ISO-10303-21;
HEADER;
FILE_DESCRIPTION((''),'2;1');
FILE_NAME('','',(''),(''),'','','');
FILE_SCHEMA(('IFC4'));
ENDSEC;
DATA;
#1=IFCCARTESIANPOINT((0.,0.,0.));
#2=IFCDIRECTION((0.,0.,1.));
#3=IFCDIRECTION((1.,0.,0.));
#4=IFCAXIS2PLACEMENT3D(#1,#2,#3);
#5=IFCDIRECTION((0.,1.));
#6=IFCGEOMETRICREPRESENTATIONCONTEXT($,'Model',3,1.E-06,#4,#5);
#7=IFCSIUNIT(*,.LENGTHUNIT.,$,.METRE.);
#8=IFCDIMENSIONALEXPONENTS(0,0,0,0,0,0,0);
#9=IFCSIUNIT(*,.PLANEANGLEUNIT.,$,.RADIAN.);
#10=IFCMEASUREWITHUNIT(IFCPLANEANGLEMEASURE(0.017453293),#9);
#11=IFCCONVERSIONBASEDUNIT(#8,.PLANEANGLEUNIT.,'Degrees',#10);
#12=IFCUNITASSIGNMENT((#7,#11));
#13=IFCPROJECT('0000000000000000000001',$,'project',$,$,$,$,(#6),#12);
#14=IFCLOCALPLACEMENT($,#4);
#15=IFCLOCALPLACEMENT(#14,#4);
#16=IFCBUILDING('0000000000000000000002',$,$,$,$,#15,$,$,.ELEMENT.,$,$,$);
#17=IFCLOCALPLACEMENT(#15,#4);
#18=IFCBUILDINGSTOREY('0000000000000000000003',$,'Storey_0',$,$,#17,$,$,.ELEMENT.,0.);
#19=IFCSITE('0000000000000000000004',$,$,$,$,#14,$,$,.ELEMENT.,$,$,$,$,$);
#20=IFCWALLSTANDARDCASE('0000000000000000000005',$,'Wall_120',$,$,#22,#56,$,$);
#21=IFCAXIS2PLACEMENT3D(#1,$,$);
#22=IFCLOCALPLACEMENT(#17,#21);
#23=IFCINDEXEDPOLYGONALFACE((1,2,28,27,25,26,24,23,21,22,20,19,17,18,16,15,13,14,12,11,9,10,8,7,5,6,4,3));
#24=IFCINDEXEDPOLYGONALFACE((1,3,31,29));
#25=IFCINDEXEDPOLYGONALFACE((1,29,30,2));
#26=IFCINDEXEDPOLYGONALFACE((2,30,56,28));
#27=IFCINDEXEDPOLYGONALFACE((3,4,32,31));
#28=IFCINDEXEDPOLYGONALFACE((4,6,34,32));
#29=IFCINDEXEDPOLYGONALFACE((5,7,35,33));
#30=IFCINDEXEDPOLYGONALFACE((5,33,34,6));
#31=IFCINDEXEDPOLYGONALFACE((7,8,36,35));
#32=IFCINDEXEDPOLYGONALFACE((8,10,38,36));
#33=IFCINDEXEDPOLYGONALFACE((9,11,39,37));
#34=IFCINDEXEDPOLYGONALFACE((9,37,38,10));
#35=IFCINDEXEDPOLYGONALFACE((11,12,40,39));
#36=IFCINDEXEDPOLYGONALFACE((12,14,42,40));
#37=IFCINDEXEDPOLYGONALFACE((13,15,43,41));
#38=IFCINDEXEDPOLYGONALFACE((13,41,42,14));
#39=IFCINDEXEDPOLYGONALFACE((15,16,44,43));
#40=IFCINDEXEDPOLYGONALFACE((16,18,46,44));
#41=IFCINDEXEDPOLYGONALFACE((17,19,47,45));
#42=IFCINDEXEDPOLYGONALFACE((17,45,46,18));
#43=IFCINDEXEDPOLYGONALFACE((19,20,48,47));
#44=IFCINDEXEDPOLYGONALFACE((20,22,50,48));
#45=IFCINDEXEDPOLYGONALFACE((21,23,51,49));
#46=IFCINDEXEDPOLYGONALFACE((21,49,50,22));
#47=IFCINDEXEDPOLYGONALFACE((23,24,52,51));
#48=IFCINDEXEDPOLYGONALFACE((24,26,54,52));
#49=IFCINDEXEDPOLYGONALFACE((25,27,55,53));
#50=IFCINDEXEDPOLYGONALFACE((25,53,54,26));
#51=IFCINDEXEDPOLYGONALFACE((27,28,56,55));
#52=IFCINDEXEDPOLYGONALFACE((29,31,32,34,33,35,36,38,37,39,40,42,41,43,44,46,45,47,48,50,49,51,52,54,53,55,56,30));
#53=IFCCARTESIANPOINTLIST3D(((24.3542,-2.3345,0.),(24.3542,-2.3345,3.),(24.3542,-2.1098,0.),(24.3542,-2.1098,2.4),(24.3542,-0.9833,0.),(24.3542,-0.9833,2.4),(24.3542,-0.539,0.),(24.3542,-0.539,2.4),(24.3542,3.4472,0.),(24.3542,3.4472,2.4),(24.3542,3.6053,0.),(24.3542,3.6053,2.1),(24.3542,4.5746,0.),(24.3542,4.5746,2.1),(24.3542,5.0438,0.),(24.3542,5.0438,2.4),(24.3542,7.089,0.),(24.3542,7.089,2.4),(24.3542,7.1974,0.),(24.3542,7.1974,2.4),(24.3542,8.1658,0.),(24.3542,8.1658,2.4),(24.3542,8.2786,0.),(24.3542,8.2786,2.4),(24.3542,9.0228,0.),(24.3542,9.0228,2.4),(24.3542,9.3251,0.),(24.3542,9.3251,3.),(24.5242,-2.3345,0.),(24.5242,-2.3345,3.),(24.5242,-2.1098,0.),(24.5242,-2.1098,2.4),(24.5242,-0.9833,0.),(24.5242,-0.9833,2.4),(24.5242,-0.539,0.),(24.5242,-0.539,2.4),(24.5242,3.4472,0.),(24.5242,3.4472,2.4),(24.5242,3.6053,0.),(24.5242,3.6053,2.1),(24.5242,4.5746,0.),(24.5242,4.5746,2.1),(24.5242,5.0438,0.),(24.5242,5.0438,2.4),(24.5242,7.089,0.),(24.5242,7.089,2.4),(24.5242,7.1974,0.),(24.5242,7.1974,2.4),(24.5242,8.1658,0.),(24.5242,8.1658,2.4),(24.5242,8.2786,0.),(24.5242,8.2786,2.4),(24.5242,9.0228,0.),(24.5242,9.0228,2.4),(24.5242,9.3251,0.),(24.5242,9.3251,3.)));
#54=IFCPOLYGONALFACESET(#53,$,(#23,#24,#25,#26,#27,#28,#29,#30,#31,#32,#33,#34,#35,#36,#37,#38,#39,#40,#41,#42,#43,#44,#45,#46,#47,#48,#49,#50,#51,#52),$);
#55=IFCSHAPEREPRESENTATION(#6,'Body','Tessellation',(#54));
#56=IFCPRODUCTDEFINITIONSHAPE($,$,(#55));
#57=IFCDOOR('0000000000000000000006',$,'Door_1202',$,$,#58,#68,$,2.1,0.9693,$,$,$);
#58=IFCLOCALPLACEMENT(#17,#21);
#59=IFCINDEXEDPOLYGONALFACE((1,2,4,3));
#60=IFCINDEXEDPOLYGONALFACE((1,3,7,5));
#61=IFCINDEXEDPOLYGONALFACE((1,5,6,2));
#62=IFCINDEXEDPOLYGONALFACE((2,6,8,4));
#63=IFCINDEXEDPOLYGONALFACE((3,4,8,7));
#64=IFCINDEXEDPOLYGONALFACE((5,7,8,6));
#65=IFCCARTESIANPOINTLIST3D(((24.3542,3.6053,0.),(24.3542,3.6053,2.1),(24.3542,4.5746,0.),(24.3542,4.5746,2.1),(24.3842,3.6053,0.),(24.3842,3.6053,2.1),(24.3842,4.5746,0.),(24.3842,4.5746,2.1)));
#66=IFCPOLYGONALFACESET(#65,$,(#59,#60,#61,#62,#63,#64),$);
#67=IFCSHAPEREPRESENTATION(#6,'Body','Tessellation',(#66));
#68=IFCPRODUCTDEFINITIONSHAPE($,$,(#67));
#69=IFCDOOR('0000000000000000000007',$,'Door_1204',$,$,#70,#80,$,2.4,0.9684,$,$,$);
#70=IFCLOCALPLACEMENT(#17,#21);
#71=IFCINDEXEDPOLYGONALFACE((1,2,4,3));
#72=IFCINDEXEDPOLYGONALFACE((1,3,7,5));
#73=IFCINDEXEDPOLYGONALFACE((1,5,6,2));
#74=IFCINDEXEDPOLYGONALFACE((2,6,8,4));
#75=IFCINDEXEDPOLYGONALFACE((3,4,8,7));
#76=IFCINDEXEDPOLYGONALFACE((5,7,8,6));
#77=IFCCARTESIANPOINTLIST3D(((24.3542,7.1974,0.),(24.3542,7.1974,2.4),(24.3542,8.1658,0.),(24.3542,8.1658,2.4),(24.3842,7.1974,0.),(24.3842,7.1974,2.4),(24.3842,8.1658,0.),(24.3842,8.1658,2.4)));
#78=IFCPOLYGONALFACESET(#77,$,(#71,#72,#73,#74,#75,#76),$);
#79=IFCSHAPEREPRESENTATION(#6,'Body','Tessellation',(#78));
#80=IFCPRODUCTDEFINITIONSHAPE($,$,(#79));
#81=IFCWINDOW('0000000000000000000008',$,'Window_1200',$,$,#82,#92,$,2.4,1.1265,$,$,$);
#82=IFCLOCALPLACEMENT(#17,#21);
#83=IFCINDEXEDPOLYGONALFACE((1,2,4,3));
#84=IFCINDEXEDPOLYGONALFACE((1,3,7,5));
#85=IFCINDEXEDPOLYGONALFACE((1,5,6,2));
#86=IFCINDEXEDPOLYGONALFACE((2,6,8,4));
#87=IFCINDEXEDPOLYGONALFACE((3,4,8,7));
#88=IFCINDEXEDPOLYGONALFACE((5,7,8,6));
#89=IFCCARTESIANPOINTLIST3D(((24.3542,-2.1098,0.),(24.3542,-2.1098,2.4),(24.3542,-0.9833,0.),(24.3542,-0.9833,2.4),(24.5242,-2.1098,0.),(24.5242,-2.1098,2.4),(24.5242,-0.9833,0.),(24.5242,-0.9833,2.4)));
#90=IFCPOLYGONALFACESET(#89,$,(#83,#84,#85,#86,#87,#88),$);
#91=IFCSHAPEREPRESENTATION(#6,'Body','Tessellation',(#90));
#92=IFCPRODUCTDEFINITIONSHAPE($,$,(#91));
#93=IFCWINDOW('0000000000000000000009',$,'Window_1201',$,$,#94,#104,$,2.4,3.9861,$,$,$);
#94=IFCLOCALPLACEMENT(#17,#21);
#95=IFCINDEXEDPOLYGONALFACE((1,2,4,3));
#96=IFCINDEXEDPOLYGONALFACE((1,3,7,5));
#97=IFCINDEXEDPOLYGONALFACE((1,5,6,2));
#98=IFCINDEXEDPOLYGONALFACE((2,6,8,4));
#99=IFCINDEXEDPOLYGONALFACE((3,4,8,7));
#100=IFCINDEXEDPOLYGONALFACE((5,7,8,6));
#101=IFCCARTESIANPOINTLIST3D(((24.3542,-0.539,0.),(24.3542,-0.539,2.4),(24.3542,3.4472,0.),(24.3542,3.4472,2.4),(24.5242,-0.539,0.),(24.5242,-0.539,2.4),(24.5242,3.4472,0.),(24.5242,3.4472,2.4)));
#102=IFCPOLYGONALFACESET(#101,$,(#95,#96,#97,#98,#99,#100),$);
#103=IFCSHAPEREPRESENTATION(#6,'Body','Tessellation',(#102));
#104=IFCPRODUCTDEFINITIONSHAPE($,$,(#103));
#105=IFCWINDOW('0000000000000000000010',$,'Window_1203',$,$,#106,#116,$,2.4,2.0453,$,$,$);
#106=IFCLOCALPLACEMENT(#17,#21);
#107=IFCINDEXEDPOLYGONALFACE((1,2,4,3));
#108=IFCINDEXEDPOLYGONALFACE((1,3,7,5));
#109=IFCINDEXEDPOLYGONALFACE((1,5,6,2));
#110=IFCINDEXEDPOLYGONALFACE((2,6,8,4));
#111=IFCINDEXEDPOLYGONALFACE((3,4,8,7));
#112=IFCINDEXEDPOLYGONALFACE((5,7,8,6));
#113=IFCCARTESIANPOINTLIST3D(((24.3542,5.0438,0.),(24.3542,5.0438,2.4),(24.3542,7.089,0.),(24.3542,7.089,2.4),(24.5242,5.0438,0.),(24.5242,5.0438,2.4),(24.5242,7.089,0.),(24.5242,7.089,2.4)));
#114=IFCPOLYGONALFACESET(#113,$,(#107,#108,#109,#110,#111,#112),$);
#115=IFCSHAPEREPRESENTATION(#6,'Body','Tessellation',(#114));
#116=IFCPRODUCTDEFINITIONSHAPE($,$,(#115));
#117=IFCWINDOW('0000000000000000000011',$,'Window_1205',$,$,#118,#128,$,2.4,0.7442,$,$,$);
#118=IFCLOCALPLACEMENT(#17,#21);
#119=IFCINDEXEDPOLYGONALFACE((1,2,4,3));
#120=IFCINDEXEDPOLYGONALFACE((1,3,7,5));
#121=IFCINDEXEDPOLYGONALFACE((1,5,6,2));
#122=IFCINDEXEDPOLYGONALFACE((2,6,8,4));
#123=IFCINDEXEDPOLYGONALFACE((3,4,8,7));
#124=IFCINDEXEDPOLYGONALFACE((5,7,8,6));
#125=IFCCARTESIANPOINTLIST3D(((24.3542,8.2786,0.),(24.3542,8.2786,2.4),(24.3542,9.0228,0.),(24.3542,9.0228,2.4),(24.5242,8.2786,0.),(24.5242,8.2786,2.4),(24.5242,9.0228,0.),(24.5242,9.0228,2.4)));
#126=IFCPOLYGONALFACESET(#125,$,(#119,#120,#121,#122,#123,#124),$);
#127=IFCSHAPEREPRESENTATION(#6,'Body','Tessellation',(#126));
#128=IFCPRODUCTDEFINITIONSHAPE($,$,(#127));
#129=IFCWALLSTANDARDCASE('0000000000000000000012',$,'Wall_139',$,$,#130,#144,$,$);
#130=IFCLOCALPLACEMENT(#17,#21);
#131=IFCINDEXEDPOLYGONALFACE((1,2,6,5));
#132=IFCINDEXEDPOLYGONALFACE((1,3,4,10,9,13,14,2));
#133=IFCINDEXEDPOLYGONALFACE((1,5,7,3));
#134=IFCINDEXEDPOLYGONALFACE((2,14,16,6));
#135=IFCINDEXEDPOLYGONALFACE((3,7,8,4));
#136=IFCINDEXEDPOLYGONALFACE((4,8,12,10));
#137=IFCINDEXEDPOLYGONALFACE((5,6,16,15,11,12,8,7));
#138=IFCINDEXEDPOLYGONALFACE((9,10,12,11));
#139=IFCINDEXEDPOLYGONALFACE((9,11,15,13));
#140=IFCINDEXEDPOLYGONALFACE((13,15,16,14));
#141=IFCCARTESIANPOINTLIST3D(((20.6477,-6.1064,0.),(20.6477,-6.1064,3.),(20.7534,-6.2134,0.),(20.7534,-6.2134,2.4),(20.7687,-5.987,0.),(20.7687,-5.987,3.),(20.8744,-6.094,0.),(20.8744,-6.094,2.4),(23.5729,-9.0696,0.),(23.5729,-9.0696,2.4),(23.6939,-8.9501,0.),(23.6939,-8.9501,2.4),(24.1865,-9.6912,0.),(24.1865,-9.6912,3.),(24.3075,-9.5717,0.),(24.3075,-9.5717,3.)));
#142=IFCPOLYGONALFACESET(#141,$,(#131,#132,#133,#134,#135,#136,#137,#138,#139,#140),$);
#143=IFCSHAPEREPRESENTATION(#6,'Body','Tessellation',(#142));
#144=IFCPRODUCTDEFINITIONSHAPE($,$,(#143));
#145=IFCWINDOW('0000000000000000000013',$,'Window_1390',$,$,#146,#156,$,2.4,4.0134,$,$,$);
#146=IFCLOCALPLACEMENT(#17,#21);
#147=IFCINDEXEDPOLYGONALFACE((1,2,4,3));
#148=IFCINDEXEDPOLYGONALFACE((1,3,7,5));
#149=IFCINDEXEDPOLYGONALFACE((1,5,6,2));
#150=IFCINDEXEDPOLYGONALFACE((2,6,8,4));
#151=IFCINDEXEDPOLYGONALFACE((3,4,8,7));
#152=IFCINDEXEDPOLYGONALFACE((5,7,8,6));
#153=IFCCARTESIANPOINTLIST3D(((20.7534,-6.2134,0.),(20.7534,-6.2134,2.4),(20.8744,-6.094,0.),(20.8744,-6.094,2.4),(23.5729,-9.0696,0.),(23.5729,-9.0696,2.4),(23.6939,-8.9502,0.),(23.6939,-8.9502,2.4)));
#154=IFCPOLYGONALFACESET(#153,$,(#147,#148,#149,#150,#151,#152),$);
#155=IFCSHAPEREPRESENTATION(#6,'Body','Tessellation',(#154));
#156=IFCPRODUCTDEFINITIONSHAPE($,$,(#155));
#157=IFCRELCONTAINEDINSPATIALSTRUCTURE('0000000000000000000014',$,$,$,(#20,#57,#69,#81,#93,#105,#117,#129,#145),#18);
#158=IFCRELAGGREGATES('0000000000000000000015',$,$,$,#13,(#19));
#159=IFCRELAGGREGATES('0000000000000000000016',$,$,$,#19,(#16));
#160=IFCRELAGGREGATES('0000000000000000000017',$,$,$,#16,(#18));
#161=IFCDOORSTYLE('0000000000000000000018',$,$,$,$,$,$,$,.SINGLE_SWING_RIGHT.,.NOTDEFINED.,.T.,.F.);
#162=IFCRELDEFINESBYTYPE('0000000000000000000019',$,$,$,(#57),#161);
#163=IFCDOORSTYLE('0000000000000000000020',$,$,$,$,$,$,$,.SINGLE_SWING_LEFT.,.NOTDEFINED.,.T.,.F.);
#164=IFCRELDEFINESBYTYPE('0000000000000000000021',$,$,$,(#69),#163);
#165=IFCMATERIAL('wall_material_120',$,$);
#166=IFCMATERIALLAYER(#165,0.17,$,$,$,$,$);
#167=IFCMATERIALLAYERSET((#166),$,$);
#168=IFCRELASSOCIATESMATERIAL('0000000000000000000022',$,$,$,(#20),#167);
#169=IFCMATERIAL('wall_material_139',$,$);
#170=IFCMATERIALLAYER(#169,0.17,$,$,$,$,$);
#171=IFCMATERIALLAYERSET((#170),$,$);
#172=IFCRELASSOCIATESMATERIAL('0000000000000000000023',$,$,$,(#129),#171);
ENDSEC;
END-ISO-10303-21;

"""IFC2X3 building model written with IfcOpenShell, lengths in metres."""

from ifc_helpers import new_model, entity, si_unit, converted_unit, direction, frame, frame_2d, origin_with_axes, place, context, project, spatial, polyline, rectangle, outline, extrude, material, layer, layer_set, layer_usage, type_object, element, fill, save


model = new_model("IFC2X3")

# Units and contexts
model_context = context("Model", 3, precision=1e-06, world=origin_with_axes(), true_north=direction((0.0, 1.0)))
ifc_project = project(units=[si_unit("LENGTHUNIT", "METRE"), converted_unit("PLANEANGLEUNIT", "Degrees", entity("IfcPlaneAngleMeasure", 0.017453293), si_unit("PLANEANGLEUNIT", "RADIAN"), dimensions=[0, 0, 0, 0, 0, 0, 0])], contexts=[model_context])

# Site, building, storey
site_placement = place(None, origin_with_axes())
site = spatial("IfcSite", under=ifc_project, at=site_placement, CompositionType="ELEMENT")
building_placement = place(site_placement, origin_with_axes())
building = spatial("IfcBuilding", under=site, at=building_placement, CompositionType="ELEMENT")
storey_placement = place(building_placement, origin_with_axes())
storey = spatial("IfcBuildingStorey", under=building, at=storey_placement, Name="Storey_0", CompositionType="ELEMENT", Elevation=0.0)

# Wall, openings, doors, windows
ifc_material_1 = material(Name="wall_material_120")
ifc_layer_1 = layer(ifc_material_1, 0.17)
ifc_layer_set_1 = layer_set([ifc_layer_1])
ifc_layer_usage_1 = layer_usage(ifc_layer_set_1, "AXIS2", "NEGATIVE", 0.0)
wall_1_placement = place(storey_placement, frame((24.3542, -2.3345, 0.0), z_axis=(0.0, 0.0, 1.0), x_axis=(0.0, 1.0, 0.0)))
wall_1 = element("IfcWallStandardCase", 1, at=wall_1_placement, inside=storey, material=ifc_layer_usage_1, Name="Wall_120", context=model_context, shape_type="SweptSolid", body=[
    extrude(outline(polyline([(0.0, 0.0), (11.6595, 0.0), (11.6595, -0.17), (0.0, -0.17), (0.0, 0.0)])), origin_with_axes(), (0.0, 0.0, 1.0), 3.0),
])
opening_1_placement = place(wall_1_placement, frame((0.2247, 0.0, 0.0), z_axis=(0.0, 0.0, 1.0), x_axis=(1.0, 0.0, 0.0)))
opening_1 = element("IfcOpeningElement", 2, at=opening_1_placement, cuts=wall_1, context=model_context, shape_type="SweptSolid", body=[
    extrude(rectangle(XDim=1.1265, YDim=2.4, at=frame_2d((1.2, -0.5633), x_axis=(0.0, 1.0))), frame((0.0, 0.01, 0.0), z_axis=(0.0, -1.0, 0.0), x_axis=(0.0, 0.0, 1.0)), (0.0, 0.0, 1.0), 0.19),
])
opening_2_placement = place(wall_1_placement, frame((1.7955, 0.0, 0.0), z_axis=(0.0, 0.0, 1.0), x_axis=(1.0, 0.0, 0.0)))
opening_2 = element("IfcOpeningElement", 3, at=opening_2_placement, cuts=wall_1, context=model_context, shape_type="SweptSolid", body=[
    extrude(rectangle(XDim=3.9861, YDim=2.4, at=frame_2d((1.2, -1.9931), x_axis=(0.0, 1.0))), frame((0.0, 0.01, 0.0), z_axis=(0.0, -1.0, 0.0), x_axis=(0.0, 0.0, 1.0)), (0.0, 0.0, 1.0), 0.19),
])
opening_3_placement = place(wall_1_placement, frame((5.9398, 0.0, 0.0), z_axis=(0.0, 0.0, 1.0), x_axis=(1.0, 0.0, 0.0)))
opening_3 = element("IfcOpeningElement", 4, at=opening_3_placement, cuts=wall_1, context=model_context, shape_type="SweptSolid", body=[
    extrude(rectangle(XDim=0.9693, YDim=2.1, at=frame_2d((1.05, -0.4846), x_axis=(0.0, 1.0))), frame((0.0, 0.01, 0.0), z_axis=(0.0, -1.0, 0.0), x_axis=(0.0, 0.0, 1.0)), (0.0, 0.0, 1.0), 0.19),
])
opening_4_placement = place(wall_1_placement, frame((7.3782, 0.0, 0.0), z_axis=(0.0, 0.0, 1.0), x_axis=(1.0, 0.0, 0.0)))
opening_4 = element("IfcOpeningElement", 5, at=opening_4_placement, cuts=wall_1, context=model_context, shape_type="SweptSolid", body=[
    extrude(rectangle(XDim=2.0453, YDim=2.4, at=frame_2d((1.2, -1.0226), x_axis=(0.0, 1.0))), frame((0.0, 0.01, 0.0), z_axis=(0.0, -1.0, 0.0), x_axis=(0.0, 0.0, 1.0)), (0.0, 0.0, 1.0), 0.19),
])
opening_5_placement = place(wall_1_placement, frame((9.5319, 0.0, 0.0), z_axis=(0.0, 0.0, 1.0), x_axis=(1.0, 0.0, 0.0)))
opening_5 = element("IfcOpeningElement", 6, at=opening_5_placement, cuts=wall_1, context=model_context, shape_type="SweptSolid", body=[
    extrude(rectangle(XDim=0.9684, YDim=2.4, at=frame_2d((1.2, -0.4842), x_axis=(0.0, 1.0))), frame((0.0, 0.01, 0.0), z_axis=(0.0, -1.0, 0.0), x_axis=(0.0, 0.0, 1.0)), (0.0, 0.0, 1.0), 0.19),
])
opening_6_placement = place(wall_1_placement, frame((10.6131, 0.0, 0.0), z_axis=(0.0, 0.0, 1.0), x_axis=(1.0, 0.0, 0.0)))
opening_6 = element("IfcOpeningElement", 7, at=opening_6_placement, cuts=wall_1, context=model_context, shape_type="SweptSolid", body=[
    extrude(rectangle(XDim=0.7442, YDim=2.4, at=frame_2d((1.2, -0.3721), x_axis=(0.0, 1.0))), frame((0.0, 0.01, 0.0), z_axis=(0.0, -1.0, 0.0), x_axis=(0.0, 0.0, 1.0)), (0.0, 0.0, 1.0), 0.19),
])
door_style_1 = type_object("IfcDoorStyle", ConstructionType="NOTDEFINED", OperationType="SINGLE_SWING_RIGHT", ParameterTakesPrecedence=True, Sizeable=False)
door_1_placement = place(storey_placement, origin_with_axes())
door_1 = element("IfcDoor", 8, at=door_1_placement, inside=storey, type_object=door_style_1, Name="Door_1202", OverallHeight=2.1, OverallWidth=0.9693, context=model_context, shape_type="SweptSolid", body=[
    extrude(outline(polyline([(24.3542, 3.6053), (24.3542, 4.5746), (24.3842, 4.5746), (24.3842, 3.6053), (24.3542, 3.6053)])), origin_with_axes(), (0.0, 0.0, 1.0), 2.1),
])
fill(opening_3, door_1)
door_style_2 = type_object("IfcDoorStyle", ConstructionType="NOTDEFINED", OperationType="SINGLE_SWING_LEFT", ParameterTakesPrecedence=True, Sizeable=False)
door_2_placement = place(storey_placement, origin_with_axes())
door_2 = element("IfcDoor", 9, at=door_2_placement, inside=storey, type_object=door_style_2, Name="Door_1204", OverallHeight=2.4, OverallWidth=0.9684, context=model_context, shape_type="SweptSolid", body=[
    extrude(outline(polyline([(24.3542, 7.1974), (24.3542, 8.1658), (24.3842, 8.1658), (24.3842, 7.1974), (24.3542, 7.1974)])), origin_with_axes(), (0.0, 0.0, 1.0), 2.4),
])
fill(opening_5, door_2)
window_1_placement = place(storey_placement, origin_with_axes())
window_1 = element("IfcWindow", 10, at=window_1_placement, inside=storey, Name="Window_1200", OverallHeight=2.4, OverallWidth=1.1265, context=model_context, shape_type="SweptSolid", body=[
    extrude(outline(polyline([(24.3542, -2.1098), (24.3542, -0.9833), (24.5242, -0.9833), (24.5242, -2.1098), (24.3542, -2.1098)])), origin_with_axes(), (0.0, 0.0, 1.0), 2.4),
])
fill(opening_1, window_1)
window_2_placement = place(storey_placement, origin_with_axes())
window_2 = element("IfcWindow", 11, at=window_2_placement, inside=storey, Name="Window_1201", OverallHeight=2.4, OverallWidth=3.9861, context=model_context, shape_type="SweptSolid", body=[
    extrude(outline(polyline([(24.3542, -0.539), (24.3542, 3.4472), (24.5242, 3.4472), (24.5242, -0.539), (24.3542, -0.539)])), origin_with_axes(), (0.0, 0.0, 1.0), 2.4),
])
fill(opening_2, window_2)
window_3_placement = place(storey_placement, origin_with_axes())
window_3 = element("IfcWindow", 12, at=window_3_placement, inside=storey, Name="Window_1203", OverallHeight=2.4, OverallWidth=2.0453, context=model_context, shape_type="SweptSolid", body=[
    extrude(outline(polyline([(24.3542, 5.0438), (24.3542, 7.089), (24.5242, 7.089), (24.5242, 5.0438), (24.3542, 5.0438)])), origin_with_axes(), (0.0, 0.0, 1.0), 2.4),
])
fill(opening_4, window_3)
window_4_placement = place(storey_placement, origin_with_axes())
window_4 = element("IfcWindow", 13, at=window_4_placement, inside=storey, Name="Window_1205", OverallHeight=2.4, OverallWidth=0.7442, context=model_context, shape_type="SweptSolid", body=[
    extrude(outline(polyline([(24.3542, 8.2786), (24.3542, 9.0228), (24.5242, 9.0228), (24.5242, 8.2786), (24.3542, 8.2786)])), origin_with_axes(), (0.0, 0.0, 1.0), 2.4),
])
fill(opening_6, window_4)

# Wall, opening, window
ifc_material_2 = material(Name="wall_material_139")
ifc_layer_2 = layer(ifc_material_2, 0.17)
ifc_layer_set_2 = layer_set([ifc_layer_2])
ifc_layer_usage_2 = layer_usage(ifc_layer_set_2, "AXIS2", "NEGATIVE", 0.0)
wall_2_placement = place(storey_placement, frame((20.7687, -5.987, 0.0), z_axis=(0.0, 0.0, 1.0), x_axis=(0.702526, -0.711658, 0.0)))
wall_2 = element("IfcWallStandardCase", 14, at=wall_2_placement, inside=storey, material=ifc_layer_usage_2, Name="Wall_139", context=model_context, shape_type="SweptSolid", body=[
    extrude(outline(polyline([(0.0, 0.0), (5.0372, 0.0), (5.0372, -0.17), (0.0, -0.17), (0.0, 0.0)])), origin_with_axes(), (0.0, 0.0, 1.0), 3.0),
])
opening_7_placement = place(wall_2_placement, frame((0.1504, 0.0, 0.0), z_axis=(0.0, 0.0, 1.0), x_axis=(1.0, 0.0, 0.0)))
opening_7 = element("IfcOpeningElement", 15, at=opening_7_placement, cuts=wall_2, context=model_context, shape_type="SweptSolid", body=[
    extrude(rectangle(XDim=4.0134, YDim=2.4, at=frame_2d((1.2, -2.0067), x_axis=(0.0, 1.0))), frame((0.0, 0.01, 0.0), z_axis=(0.0, -1.0, 0.0), x_axis=(0.0, 0.0, 1.0)), (0.0, 0.0, 1.0), 0.19),
])
window_5_placement = place(storey_placement, origin_with_axes())
window_5 = element("IfcWindow", 16, at=window_5_placement, inside=storey, Name="Window_1390", OverallHeight=2.4, OverallWidth=4.0134, context=model_context, shape_type="SweptSolid", body=[
    extrude(outline(polyline([(20.8744, -6.094), (23.6939, -8.9502), (23.5729, -9.0696), (20.7534, -6.2134), (20.8744, -6.094)])), origin_with_axes(), (0.0, 0.0, 1.0), 2.4),
])
fill(opening_7, window_5)

save(model, "model.ifc")
